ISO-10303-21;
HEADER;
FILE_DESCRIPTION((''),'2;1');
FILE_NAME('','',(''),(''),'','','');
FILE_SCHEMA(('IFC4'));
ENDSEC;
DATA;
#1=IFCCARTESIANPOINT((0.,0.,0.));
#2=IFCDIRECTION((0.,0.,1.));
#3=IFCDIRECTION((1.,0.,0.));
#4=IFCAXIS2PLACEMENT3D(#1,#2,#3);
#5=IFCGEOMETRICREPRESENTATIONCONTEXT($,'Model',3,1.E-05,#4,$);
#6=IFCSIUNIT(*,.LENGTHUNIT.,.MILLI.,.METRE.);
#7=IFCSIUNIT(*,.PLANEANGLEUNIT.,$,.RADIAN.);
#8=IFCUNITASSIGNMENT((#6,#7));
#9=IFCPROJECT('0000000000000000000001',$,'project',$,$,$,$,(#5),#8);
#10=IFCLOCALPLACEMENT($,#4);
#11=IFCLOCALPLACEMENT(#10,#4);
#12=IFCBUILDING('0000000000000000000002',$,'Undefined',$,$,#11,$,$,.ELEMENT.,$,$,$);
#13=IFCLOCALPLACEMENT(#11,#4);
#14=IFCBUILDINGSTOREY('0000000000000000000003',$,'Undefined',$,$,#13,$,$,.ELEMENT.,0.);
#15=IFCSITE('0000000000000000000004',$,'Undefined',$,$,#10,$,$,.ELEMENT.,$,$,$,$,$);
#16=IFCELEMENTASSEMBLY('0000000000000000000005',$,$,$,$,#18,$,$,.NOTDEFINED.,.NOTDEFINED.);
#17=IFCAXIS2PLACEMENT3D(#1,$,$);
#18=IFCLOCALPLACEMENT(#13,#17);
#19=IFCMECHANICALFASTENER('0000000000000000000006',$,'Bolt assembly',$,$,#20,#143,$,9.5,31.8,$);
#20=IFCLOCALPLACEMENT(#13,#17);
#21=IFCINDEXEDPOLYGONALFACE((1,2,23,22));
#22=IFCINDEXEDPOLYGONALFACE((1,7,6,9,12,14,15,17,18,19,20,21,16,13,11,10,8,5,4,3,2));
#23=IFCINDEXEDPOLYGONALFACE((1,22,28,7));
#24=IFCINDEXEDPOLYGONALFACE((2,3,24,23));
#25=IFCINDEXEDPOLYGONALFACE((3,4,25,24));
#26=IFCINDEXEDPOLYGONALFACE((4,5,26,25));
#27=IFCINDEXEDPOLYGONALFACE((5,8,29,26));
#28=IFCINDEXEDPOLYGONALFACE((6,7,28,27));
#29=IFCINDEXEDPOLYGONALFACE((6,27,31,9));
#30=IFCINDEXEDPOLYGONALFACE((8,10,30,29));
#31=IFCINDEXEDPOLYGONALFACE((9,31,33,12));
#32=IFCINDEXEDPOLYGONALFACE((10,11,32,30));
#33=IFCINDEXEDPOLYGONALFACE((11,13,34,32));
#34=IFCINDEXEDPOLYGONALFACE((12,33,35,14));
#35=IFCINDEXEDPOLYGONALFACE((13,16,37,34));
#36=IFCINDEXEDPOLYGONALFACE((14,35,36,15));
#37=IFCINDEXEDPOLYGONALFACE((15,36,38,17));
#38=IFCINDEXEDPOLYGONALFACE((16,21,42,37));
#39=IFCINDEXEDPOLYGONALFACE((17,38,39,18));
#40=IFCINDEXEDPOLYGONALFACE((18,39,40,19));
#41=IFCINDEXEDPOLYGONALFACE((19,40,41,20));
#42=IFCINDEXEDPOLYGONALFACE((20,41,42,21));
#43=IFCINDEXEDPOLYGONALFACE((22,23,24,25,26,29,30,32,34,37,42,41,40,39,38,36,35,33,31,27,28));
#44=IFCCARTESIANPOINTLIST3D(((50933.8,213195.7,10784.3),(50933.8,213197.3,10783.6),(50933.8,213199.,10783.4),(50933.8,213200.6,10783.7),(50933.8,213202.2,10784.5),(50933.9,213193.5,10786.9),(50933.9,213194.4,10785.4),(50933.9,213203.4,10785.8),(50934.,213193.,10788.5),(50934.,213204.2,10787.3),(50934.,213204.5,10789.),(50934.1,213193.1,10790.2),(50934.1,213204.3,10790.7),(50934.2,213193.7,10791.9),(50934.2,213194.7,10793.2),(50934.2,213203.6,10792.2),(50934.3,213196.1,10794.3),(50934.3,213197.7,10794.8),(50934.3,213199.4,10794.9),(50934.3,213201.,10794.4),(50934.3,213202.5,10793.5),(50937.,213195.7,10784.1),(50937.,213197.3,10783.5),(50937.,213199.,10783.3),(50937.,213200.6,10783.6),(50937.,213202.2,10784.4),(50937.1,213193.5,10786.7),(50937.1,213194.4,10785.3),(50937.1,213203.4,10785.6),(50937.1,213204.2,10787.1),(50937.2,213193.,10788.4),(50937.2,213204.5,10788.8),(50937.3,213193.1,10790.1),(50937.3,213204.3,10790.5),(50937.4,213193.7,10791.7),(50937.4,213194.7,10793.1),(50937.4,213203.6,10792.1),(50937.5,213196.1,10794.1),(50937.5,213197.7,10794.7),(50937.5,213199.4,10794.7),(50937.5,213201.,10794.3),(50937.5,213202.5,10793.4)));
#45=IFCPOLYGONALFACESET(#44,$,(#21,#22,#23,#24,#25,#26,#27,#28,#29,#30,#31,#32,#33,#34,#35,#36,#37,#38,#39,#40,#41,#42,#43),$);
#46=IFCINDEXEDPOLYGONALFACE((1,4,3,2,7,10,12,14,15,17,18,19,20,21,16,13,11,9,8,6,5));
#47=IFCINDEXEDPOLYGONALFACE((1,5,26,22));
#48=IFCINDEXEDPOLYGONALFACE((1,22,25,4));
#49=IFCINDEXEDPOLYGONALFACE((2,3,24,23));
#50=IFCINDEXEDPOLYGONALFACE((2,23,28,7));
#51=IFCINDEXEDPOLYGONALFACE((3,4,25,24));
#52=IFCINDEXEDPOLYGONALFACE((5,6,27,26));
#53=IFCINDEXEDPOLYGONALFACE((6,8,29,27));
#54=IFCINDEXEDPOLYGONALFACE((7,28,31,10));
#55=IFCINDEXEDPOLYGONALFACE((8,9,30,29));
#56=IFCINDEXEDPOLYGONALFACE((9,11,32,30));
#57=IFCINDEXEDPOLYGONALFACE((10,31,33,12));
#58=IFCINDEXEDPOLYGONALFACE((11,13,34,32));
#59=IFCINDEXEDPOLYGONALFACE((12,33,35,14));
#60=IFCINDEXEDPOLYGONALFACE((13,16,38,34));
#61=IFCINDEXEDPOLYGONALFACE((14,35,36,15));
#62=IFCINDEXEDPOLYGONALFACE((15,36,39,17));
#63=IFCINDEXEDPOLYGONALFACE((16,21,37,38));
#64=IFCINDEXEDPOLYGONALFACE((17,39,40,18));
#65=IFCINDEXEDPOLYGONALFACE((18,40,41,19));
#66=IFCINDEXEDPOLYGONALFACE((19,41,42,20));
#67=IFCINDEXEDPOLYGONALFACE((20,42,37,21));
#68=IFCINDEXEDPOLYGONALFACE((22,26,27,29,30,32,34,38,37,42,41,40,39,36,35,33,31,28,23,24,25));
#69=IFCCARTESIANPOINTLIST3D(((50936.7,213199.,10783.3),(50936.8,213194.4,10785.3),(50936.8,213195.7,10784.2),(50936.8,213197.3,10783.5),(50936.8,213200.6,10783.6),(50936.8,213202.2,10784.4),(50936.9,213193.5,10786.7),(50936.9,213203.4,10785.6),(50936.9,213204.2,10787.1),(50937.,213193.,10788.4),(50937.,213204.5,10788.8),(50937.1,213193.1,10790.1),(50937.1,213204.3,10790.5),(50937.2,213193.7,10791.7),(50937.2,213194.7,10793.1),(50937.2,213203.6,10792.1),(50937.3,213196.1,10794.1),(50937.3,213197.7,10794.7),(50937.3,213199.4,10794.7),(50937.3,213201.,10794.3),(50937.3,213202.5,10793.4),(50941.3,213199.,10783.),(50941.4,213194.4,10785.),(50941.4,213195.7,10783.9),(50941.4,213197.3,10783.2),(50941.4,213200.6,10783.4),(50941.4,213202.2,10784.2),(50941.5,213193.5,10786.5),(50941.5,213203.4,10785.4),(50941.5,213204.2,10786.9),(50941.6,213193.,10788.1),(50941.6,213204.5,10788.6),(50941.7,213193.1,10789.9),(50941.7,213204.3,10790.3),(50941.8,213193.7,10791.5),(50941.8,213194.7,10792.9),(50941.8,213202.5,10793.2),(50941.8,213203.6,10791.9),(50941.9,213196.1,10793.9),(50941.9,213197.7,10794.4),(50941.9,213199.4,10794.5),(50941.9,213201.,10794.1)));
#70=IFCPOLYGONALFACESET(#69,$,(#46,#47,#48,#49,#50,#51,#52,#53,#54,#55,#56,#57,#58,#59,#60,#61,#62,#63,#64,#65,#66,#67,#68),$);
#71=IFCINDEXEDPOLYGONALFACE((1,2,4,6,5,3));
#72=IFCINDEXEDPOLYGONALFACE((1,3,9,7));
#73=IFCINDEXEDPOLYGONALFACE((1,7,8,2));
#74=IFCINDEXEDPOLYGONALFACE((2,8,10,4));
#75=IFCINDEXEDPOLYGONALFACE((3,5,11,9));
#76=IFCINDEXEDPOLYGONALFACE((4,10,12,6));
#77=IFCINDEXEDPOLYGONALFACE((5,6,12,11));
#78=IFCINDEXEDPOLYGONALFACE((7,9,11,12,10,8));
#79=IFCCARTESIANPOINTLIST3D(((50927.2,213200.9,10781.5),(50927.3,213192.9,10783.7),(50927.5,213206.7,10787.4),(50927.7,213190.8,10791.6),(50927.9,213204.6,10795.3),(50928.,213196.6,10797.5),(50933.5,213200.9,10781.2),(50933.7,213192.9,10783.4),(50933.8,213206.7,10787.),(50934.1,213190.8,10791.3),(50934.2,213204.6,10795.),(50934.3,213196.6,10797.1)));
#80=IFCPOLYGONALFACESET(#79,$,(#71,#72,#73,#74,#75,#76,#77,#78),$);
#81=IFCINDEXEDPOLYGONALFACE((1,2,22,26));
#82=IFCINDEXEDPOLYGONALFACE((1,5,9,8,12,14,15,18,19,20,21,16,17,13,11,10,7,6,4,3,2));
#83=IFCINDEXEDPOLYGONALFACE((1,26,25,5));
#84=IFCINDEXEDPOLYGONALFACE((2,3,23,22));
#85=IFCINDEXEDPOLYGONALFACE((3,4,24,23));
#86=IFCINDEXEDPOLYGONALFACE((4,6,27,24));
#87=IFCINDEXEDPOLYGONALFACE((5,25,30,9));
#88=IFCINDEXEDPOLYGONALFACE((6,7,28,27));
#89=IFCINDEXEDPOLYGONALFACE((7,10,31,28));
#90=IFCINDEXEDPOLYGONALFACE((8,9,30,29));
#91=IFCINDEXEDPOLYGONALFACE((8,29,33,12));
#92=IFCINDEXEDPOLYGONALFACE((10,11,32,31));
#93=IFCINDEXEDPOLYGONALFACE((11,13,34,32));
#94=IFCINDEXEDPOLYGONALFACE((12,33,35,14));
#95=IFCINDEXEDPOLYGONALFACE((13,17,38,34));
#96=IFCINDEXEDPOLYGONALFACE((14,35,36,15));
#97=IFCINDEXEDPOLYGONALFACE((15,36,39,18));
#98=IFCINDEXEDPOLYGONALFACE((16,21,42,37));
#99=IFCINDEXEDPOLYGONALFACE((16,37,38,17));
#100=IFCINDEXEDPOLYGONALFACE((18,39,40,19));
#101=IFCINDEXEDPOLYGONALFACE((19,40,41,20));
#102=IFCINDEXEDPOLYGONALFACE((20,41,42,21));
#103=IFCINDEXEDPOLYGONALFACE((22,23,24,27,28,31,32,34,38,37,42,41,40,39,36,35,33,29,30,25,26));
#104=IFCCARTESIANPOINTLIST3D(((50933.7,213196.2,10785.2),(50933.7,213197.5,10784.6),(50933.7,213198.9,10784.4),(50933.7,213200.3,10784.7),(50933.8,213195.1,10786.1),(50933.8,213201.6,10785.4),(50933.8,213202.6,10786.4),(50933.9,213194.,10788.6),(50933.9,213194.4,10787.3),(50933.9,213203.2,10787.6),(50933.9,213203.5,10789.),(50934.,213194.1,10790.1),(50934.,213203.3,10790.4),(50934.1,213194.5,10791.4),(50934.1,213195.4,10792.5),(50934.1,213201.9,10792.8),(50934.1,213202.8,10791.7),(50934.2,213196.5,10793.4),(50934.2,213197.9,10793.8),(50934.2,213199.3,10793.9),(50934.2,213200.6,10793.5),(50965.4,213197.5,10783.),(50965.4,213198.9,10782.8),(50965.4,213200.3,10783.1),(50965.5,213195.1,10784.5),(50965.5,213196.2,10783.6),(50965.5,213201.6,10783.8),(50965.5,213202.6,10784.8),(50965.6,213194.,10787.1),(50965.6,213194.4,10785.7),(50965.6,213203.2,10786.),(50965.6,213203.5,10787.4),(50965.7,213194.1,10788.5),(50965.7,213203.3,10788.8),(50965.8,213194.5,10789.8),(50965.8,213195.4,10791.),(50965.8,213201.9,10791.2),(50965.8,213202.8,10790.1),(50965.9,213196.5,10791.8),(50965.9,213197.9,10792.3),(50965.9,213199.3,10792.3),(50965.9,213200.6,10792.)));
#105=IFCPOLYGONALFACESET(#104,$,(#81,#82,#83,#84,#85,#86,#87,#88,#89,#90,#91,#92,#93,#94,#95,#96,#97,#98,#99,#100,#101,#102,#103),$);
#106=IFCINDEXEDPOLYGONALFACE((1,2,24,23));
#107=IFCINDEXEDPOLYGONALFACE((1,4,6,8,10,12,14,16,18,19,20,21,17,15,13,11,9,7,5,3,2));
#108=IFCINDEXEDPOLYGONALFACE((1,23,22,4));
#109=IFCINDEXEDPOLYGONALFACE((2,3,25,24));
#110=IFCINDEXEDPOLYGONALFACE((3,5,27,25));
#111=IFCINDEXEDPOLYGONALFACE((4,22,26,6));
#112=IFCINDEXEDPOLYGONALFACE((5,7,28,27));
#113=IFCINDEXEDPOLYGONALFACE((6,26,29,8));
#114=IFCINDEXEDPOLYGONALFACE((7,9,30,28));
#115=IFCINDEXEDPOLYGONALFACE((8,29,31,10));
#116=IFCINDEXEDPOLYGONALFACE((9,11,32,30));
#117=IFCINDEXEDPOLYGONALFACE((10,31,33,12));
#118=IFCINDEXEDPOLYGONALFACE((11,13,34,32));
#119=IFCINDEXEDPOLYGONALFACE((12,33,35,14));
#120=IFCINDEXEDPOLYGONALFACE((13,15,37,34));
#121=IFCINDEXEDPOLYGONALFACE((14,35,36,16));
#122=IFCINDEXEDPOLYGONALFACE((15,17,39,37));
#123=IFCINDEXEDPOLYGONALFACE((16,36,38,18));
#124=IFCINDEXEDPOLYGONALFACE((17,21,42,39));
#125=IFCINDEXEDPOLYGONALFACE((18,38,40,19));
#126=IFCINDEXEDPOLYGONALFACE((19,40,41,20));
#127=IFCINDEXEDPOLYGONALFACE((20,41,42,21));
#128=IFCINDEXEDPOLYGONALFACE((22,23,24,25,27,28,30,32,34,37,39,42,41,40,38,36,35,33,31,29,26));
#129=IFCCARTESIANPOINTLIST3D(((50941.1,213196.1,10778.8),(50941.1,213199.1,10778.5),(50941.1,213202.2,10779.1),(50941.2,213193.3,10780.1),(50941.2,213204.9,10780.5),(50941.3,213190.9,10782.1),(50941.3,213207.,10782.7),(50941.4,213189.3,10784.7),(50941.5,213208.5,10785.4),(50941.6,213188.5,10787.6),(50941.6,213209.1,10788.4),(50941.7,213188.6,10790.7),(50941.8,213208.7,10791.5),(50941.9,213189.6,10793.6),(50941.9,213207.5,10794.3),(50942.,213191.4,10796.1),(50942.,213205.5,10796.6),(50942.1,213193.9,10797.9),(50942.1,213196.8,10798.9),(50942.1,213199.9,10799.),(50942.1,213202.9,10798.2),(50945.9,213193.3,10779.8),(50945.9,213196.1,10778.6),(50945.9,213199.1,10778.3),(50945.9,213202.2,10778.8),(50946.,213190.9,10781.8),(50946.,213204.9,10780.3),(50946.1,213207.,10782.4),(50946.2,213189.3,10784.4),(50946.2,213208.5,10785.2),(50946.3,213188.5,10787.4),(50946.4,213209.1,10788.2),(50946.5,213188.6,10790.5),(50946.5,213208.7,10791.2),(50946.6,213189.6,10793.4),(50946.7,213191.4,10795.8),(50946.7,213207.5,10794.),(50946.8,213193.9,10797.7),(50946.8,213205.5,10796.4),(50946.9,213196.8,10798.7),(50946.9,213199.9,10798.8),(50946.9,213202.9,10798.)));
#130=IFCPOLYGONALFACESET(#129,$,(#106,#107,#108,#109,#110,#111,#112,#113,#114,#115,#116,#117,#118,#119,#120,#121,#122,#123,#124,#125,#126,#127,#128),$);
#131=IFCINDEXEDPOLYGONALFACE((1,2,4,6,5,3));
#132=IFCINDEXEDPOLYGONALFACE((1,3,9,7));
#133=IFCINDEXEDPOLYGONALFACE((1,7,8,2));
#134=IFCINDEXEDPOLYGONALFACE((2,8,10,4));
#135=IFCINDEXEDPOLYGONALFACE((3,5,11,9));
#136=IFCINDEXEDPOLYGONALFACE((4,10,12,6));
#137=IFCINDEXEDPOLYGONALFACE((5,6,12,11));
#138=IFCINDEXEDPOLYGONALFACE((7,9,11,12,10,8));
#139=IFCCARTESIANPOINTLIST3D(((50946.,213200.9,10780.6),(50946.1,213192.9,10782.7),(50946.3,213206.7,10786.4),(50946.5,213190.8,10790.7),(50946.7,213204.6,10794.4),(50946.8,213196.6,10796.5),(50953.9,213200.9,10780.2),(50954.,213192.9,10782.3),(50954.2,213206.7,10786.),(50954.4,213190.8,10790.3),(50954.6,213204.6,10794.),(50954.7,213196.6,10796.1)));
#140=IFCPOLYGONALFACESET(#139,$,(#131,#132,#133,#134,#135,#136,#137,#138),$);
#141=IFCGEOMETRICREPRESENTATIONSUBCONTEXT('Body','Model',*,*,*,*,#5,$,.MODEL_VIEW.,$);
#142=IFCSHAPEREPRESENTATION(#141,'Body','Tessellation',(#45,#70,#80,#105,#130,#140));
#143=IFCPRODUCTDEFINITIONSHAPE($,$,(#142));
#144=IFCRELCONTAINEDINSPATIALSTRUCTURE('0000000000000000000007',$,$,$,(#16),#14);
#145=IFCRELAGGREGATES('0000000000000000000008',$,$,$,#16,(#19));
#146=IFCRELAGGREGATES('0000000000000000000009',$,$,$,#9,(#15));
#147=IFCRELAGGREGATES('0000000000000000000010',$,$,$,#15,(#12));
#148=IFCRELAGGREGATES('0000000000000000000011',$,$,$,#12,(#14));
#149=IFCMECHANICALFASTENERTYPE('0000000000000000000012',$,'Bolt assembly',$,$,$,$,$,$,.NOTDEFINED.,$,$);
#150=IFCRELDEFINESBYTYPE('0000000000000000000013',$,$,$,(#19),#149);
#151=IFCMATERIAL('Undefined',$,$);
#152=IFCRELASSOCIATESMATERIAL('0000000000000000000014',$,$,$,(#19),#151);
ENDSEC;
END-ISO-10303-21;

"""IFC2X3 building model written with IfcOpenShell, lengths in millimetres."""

from ifc_helpers import new_model, si_unit, frame, origin_with_axes, origin_2d_with_axis, place, context, subcontext, project, spatial, polyline, circle, outline, extrude, source, transform, mapped, material, type_object, element, aggregate, save


model = new_model("IFC2X3")

# Units and contexts
model_context = context("Model", 3, precision=1e-05, world=origin_with_axes())
body_context = subcontext(model_context, "Body", "Model", "MODEL_VIEW")
ifc_project = project(units=[si_unit("LENGTHUNIT", "METRE", prefix="MILLI"), si_unit("PLANEANGLEUNIT", "RADIAN")], contexts=[model_context])

# Site, building, storey
site_placement = place(None, origin_with_axes())
site = spatial("IfcSite", under=ifc_project, at=site_placement, Name="Undefined", CompositionType="ELEMENT")
building_placement = place(site_placement, origin_with_axes())
building = spatial("IfcBuilding", under=site, at=building_placement, Name="Undefined", CompositionType="ELEMENT")
storey_placement = place(building_placement, origin_with_axes())
storey = spatial("IfcBuildingStorey", under=building, at=storey_placement, Name="Undefined", CompositionType="ELEMENT", Elevation=0.0)

# Shared definitions
ifc_material_1 = material(Name="Undefined")
mechanical_fastener_type = type_object("IfcMechanicalFastenerType", Name="Bolt assembly")

# Element assembly, mechanical fastener
assembly_1_placement = place(storey_placement, origin_with_axes())
assembly_1 = element("IfcElementAssembly", 1, at=assembly_1_placement, inside=storey, AssemblyPlace="NOTDEFINED", PredefinedType="NOTDEFINED")
shared_shape_1 = source(origin_with_axes(), body_context, "Body", "SweptSolid", [
    extrude(circle(Radius=5.8, at=origin_2d_with_axis()), frame((0.0, -7.6, 0.0), z_axis=(0.0, 1.0, 0.0), x_axis=(1.0, 0.0, 0.0)), (0.0, 0.0, 1.0), 3.2),
    extrude(circle(Radius=5.8, at=origin_2d_with_axis()), frame((0.0, -4.6, 0.0), z_axis=(0.0, 1.0, 0.0), x_axis=(1.0, 0.0, 0.0)), (0.0, 0.0, 1.0), 4.6),
    extrude(outline(polyline([(7.1, -4.1), (7.1, 4.1), (0.0, 8.2), (-7.1, 4.1), (-7.1, -4.1), (0.0, -8.2), (7.1, -4.1)])), frame((0.0, -14.0, 0.0), z_axis=(0.0, 1.0, 0.0), x_axis=(1.0, 0.0, 0.0)), (0.0, 0.0, 1.0), 6.3),
    extrude(circle(Radius=4.8, at=origin_2d_with_axis()), frame((0.0, -7.7, 0.0), z_axis=(0.0, 1.0, 0.0), x_axis=(1.0, 0.0, 0.0)), (0.0, 0.0, 1.0), 31.8),
    extrude(circle(Radius=10.3, at=origin_2d_with_axis()), frame((0.0, 0.0, 0.0), z_axis=(0.0, 1.0, 0.0), x_axis=(1.0, 0.0, 0.0)), (0.0, 0.0, 1.0), 4.8),
    extrude(outline(polyline([(7.1, -4.1), (7.1, 4.1), (0.0, 8.2), (-7.1, 4.1), (-7.1, -4.1), (0.0, -8.2), (7.1, -4.1)])), frame((0.0, 4.8, 0.0), z_axis=(0.0, 1.0, 0.0), x_axis=(1.0, 0.0, 0.0)), (0.0, 0.0, 1.0), 7.9),
])
mechanical_fastener_1_placement = place(assembly_1_placement, frame((50941.6, 213198.7, 10788.8), z_axis=(0.035282, 0.707107, 0.706226), x_axis=(0.035281, -0.707107, 0.706226)))
mechanical_fastener_1 = element("IfcMechanicalFastener", 2, at=mechanical_fastener_1_placement, type_object=mechanical_fastener_type, material=ifc_material_1, Name="Bolt assembly", NominalDiameter=9.5, NominalLength=31.8, context=body_context, shape_type="MappedRepresentation", body=[
    mapped(shared_shape_1, transform((0.0, 0.0, 0.0))),
])
aggregate(assembly_1, [mechanical_fastener_1])

save(model, "model.ifc")
